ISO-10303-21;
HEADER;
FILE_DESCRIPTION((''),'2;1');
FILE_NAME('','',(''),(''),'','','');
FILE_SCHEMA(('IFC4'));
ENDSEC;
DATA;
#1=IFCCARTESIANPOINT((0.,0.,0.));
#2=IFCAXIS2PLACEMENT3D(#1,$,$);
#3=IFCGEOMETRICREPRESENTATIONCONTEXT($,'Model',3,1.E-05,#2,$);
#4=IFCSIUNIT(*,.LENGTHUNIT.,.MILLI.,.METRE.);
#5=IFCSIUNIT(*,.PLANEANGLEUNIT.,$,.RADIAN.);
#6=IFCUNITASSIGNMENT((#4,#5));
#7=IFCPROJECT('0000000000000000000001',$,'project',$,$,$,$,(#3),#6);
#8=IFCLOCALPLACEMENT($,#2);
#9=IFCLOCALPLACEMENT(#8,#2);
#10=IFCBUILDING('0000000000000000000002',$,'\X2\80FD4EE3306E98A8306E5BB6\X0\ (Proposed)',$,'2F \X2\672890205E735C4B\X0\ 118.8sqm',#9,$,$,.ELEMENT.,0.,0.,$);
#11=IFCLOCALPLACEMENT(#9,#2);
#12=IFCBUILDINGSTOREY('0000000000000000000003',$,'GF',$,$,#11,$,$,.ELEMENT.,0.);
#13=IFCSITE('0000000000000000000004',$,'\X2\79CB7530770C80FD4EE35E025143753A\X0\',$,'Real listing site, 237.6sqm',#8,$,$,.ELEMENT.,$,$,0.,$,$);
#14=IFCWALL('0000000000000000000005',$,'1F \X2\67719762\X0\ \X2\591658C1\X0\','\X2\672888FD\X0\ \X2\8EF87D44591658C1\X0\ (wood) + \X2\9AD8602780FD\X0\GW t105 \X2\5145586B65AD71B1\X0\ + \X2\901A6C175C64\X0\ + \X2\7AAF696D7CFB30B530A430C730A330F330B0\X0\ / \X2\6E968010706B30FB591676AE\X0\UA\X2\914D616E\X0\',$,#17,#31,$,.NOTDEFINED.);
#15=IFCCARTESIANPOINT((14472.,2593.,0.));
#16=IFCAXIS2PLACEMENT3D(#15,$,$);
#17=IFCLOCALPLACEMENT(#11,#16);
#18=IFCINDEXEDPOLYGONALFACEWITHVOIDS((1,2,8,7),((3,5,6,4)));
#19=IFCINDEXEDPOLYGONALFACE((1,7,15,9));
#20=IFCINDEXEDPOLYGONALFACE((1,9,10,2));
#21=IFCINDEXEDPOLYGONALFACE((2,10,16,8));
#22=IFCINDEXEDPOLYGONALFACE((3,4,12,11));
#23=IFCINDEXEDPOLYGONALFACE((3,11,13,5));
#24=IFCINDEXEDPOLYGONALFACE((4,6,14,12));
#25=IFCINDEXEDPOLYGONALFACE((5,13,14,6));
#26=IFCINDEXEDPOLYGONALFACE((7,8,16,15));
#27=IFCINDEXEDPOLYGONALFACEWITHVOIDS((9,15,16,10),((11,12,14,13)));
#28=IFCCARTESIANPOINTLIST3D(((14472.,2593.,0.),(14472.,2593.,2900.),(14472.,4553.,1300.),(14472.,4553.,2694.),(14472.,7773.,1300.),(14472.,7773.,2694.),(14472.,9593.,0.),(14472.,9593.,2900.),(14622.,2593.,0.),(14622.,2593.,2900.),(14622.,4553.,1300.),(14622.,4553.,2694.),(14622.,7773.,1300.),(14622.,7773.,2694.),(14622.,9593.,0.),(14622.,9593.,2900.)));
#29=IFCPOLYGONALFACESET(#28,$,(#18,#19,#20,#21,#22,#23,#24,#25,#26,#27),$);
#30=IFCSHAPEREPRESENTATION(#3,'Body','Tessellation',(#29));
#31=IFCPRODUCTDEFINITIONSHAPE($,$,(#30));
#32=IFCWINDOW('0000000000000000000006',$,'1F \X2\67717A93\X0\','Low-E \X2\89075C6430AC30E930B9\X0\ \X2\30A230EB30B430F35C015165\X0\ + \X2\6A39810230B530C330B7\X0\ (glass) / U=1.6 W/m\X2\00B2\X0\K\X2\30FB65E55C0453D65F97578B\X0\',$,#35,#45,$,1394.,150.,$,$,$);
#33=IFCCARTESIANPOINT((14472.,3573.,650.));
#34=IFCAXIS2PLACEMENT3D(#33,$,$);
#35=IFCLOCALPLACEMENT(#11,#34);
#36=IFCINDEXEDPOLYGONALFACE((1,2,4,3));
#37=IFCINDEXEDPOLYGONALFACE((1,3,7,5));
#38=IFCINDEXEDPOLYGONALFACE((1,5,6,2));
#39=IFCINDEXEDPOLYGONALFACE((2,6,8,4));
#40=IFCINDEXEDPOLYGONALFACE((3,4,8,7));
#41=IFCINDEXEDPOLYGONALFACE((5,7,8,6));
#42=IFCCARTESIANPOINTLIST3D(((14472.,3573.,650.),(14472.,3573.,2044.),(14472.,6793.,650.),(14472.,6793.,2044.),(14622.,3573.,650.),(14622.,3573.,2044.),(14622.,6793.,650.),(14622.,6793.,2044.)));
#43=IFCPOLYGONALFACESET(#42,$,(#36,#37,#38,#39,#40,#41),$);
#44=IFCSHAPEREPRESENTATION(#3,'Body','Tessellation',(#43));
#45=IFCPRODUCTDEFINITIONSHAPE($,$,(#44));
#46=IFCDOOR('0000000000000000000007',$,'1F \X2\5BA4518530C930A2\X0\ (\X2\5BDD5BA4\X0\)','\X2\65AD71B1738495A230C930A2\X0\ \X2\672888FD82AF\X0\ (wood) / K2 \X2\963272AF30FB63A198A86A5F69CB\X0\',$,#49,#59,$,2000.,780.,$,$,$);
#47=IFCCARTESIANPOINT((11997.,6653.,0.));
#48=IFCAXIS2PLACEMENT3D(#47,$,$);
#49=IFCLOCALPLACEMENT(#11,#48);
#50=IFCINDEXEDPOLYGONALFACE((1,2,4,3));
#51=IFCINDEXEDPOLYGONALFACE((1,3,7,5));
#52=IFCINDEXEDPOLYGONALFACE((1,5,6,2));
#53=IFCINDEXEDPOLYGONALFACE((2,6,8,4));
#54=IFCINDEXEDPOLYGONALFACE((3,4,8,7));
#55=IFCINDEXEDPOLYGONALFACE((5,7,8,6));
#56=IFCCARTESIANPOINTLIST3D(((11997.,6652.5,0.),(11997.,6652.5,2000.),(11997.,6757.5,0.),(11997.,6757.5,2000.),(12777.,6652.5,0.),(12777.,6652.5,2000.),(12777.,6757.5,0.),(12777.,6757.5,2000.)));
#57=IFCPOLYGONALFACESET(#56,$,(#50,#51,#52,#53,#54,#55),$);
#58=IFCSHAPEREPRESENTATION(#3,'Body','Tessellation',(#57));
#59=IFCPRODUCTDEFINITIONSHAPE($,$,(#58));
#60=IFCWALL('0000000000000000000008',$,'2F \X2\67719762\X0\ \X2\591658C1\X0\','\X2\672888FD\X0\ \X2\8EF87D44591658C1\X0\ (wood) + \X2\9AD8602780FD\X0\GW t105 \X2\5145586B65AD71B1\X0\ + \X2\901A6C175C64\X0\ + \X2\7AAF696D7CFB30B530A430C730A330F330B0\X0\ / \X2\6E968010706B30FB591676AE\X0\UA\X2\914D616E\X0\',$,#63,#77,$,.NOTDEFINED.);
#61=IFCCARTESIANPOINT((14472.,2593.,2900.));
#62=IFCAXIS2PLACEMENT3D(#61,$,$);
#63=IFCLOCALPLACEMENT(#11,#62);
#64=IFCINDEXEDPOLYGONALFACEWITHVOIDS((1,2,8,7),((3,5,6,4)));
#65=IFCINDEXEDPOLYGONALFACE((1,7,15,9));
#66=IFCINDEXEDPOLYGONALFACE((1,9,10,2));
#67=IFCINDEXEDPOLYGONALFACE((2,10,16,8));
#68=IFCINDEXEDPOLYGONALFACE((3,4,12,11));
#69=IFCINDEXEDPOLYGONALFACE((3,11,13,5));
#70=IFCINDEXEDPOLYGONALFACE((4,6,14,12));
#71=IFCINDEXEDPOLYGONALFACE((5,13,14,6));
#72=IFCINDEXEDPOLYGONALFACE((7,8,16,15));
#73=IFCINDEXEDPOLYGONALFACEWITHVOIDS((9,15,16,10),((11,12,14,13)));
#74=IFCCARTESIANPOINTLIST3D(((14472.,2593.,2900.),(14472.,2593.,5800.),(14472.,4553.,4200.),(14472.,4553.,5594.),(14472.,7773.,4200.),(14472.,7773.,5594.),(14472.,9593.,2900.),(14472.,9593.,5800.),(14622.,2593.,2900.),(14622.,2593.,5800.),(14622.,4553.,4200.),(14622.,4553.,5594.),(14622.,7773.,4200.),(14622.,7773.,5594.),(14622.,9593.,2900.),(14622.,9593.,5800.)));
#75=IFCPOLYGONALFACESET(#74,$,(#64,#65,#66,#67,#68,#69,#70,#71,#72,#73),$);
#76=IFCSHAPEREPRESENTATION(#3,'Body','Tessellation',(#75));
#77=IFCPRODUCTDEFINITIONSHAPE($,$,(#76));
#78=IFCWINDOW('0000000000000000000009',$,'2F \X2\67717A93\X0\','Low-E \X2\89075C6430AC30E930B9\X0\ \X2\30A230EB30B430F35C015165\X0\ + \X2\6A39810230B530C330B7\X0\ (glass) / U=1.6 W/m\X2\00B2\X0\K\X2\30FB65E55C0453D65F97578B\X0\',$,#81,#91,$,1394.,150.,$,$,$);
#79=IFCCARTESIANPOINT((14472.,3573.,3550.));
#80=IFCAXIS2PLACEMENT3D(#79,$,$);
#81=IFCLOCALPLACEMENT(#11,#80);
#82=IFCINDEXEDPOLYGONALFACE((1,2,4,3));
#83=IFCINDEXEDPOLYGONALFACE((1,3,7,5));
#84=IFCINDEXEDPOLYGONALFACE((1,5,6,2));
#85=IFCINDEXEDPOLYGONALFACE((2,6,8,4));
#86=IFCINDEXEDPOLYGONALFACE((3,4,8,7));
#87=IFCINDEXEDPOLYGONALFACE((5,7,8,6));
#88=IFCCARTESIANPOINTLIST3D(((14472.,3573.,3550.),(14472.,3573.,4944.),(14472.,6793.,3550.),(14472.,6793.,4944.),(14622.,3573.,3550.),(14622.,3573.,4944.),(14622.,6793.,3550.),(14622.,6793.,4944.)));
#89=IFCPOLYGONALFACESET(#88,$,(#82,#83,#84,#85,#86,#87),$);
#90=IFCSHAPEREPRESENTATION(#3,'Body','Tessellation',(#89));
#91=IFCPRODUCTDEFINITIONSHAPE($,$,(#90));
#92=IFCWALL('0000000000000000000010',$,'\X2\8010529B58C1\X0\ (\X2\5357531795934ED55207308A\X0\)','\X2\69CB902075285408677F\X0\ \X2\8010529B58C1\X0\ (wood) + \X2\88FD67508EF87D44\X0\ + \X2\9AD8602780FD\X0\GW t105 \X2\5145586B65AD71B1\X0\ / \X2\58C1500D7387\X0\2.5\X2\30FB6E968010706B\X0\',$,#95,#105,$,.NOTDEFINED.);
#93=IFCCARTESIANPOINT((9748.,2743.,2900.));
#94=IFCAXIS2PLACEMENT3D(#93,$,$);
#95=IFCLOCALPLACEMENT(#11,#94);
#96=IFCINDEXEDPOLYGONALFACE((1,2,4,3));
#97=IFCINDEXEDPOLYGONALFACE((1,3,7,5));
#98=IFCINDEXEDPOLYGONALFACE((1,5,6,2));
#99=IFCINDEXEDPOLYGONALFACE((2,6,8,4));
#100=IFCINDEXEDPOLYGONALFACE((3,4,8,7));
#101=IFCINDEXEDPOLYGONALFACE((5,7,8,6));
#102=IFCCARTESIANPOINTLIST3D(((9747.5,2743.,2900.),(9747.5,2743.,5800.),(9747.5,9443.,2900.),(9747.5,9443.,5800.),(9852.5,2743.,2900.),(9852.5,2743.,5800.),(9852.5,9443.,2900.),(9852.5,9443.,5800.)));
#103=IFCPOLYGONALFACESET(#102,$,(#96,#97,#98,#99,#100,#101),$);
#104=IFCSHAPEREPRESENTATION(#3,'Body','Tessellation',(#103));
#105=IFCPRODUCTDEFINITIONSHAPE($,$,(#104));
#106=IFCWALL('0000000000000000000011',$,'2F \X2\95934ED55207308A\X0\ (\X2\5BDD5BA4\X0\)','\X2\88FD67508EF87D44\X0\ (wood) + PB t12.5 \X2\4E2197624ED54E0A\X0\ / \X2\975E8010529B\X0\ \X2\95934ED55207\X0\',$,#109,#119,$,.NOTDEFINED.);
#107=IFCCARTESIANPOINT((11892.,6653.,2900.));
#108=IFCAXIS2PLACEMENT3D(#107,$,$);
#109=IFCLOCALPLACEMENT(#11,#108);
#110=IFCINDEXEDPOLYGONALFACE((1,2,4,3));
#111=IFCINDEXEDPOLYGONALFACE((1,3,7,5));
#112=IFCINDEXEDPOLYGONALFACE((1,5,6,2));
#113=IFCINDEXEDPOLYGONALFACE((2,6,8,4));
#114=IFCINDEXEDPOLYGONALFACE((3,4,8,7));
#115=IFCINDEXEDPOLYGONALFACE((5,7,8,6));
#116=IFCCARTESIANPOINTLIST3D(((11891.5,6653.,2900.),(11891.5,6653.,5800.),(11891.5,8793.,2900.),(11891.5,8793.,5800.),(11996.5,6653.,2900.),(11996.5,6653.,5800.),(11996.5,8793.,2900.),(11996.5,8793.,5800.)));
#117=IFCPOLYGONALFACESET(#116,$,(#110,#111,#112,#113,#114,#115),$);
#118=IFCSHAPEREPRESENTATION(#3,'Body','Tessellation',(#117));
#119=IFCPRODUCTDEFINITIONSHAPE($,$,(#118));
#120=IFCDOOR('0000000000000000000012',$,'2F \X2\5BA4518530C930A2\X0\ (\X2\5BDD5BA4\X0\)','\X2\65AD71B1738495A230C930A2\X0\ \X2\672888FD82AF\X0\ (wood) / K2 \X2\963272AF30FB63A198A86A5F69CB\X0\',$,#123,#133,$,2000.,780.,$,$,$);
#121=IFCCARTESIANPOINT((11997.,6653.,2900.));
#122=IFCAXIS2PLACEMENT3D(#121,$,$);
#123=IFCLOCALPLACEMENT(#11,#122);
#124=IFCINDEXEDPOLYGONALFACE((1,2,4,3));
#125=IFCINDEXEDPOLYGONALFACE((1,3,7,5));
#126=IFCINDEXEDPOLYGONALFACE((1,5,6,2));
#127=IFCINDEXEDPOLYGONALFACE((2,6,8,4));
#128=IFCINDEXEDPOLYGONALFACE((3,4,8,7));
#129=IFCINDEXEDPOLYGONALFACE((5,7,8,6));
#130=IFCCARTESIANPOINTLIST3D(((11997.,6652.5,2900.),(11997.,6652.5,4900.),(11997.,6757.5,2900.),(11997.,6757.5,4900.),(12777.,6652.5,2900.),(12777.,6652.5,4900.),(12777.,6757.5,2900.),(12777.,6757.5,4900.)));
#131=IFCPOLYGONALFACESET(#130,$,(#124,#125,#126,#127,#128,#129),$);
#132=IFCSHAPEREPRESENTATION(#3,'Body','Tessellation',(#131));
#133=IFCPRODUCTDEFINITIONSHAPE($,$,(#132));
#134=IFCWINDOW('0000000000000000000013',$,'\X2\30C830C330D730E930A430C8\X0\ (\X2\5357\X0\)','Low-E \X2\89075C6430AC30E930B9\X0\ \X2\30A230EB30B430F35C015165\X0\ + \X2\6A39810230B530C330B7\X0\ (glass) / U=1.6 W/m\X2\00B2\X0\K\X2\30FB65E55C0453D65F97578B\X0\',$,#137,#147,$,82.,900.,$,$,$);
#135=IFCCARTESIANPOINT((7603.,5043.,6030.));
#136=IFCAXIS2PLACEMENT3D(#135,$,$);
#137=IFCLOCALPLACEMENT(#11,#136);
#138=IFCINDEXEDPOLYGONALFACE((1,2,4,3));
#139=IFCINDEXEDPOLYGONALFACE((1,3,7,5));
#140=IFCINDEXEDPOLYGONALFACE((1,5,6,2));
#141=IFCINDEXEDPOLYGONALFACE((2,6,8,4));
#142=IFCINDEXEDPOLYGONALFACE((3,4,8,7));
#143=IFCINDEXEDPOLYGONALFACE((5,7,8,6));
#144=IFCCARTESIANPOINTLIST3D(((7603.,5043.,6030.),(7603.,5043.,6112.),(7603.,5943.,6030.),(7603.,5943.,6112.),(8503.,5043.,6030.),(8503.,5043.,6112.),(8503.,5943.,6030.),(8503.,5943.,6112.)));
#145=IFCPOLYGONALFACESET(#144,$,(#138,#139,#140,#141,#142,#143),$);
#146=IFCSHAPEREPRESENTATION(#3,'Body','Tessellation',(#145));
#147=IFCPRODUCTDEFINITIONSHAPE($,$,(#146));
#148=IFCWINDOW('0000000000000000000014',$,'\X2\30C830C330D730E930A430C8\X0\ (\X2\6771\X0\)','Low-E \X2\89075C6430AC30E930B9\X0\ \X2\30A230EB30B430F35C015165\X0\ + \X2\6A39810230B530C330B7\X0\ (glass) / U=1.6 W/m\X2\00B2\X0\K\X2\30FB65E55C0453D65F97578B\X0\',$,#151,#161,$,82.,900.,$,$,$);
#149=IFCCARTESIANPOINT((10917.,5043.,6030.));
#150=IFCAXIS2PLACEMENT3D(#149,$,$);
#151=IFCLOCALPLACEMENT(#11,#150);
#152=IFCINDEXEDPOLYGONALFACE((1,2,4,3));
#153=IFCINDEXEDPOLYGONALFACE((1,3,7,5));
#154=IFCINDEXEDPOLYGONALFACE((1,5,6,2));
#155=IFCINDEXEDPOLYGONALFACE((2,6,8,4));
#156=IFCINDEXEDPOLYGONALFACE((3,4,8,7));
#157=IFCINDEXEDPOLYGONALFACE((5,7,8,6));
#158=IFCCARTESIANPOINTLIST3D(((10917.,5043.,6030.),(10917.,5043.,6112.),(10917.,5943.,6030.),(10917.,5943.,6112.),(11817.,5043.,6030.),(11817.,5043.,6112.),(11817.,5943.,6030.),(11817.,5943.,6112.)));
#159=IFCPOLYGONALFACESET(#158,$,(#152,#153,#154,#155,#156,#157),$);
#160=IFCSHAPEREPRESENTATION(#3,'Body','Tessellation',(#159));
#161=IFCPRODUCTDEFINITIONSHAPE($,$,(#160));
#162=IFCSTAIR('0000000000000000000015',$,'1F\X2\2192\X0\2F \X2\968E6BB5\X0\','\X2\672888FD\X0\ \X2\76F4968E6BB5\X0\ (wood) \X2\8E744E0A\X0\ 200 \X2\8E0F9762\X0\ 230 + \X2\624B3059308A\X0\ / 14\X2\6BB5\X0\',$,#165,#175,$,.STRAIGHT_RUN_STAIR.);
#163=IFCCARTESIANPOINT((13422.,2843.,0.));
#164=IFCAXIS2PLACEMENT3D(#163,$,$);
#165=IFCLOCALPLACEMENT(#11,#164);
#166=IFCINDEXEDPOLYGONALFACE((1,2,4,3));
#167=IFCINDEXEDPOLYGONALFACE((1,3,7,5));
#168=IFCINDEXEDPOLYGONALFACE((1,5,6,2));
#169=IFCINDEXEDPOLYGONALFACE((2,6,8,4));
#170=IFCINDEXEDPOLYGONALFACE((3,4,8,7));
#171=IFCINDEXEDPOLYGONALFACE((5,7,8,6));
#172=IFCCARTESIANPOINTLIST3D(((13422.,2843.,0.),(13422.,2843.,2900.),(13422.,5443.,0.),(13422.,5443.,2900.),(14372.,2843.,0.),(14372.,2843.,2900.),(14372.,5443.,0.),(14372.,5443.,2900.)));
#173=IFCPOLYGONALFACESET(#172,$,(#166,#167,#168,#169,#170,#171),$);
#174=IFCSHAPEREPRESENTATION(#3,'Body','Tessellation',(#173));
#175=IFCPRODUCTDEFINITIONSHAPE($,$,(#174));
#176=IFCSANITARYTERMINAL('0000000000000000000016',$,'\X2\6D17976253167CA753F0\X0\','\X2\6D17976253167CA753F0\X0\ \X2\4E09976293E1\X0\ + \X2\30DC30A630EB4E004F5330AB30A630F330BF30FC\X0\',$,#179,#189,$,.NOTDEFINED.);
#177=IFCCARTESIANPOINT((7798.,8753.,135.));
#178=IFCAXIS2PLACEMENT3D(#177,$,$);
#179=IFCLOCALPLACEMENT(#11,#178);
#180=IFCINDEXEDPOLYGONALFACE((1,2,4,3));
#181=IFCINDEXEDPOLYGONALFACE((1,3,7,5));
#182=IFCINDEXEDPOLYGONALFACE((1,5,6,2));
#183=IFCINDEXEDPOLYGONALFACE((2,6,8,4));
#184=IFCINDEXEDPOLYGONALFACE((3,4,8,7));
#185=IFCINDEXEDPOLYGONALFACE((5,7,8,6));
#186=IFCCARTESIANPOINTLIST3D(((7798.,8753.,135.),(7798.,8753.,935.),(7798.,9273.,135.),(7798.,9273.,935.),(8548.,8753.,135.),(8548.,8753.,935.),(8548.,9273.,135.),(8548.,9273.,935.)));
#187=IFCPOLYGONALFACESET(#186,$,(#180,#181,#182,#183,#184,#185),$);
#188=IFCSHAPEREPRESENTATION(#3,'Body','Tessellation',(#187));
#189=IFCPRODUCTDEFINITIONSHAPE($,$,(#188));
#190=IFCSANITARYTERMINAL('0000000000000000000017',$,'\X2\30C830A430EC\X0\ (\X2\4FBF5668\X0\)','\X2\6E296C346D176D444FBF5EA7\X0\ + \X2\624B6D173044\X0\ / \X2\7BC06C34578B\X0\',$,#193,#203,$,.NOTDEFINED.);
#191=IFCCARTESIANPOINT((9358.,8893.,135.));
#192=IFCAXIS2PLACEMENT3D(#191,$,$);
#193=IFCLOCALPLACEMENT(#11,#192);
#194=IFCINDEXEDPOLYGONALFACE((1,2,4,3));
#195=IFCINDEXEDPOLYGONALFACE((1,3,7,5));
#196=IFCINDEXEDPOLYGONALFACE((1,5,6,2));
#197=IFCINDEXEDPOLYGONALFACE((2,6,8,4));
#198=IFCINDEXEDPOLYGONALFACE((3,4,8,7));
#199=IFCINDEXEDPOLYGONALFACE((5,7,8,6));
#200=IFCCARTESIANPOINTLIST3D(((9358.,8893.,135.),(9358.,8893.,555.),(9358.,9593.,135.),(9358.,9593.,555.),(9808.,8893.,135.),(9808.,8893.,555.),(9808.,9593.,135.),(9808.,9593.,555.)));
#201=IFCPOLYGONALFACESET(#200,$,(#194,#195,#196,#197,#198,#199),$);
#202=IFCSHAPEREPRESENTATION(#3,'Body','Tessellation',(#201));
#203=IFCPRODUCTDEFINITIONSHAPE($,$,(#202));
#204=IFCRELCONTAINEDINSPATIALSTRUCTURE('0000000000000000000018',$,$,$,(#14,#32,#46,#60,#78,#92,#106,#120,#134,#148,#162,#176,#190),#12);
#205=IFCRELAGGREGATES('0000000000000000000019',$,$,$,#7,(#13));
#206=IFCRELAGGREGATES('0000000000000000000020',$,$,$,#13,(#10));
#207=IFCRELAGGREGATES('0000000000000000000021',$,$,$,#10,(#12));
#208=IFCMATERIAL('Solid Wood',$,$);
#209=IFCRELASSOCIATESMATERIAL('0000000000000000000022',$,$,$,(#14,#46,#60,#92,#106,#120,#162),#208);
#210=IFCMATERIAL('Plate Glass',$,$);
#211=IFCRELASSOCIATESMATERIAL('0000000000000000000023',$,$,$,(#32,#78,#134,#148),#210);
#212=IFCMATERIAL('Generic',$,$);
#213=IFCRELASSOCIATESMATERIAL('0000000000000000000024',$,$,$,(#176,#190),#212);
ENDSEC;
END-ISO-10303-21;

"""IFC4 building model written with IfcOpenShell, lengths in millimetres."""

from ifc_helpers import new_model, si_unit, frame, frame_2d, origin, place, context, project, spatial, rectangle, extrude, material, element, fill, save


model = new_model("IFC4")

# Units and contexts
model_context = context("Model", 3, precision=1e-05, world=origin())
ifc_project = project(units=[si_unit("LENGTHUNIT", "METRE", prefix="MILLI"), si_unit("PLANEANGLEUNIT", "RADIAN")], contexts=[model_context])

# Site, building, storey
site_placement = place(None, origin())
site = spatial("IfcSite", under=ifc_project, at=site_placement, Name="秋田県能代市元町", ObjectType="Real listing site, 237.6sqm", CompositionType="ELEMENT", RefElevation=0.0)
building_placement = place(site_placement, origin())
building = spatial("IfcBuilding", under=site, at=building_placement, Name="能代の風の家 (Proposed)", ObjectType="2F 木造平屋 118.8sqm", CompositionType="ELEMENT", ElevationOfRefHeight=0.0, ElevationOfTerrain=0.0)
storey_placement = place(building_placement, origin())
storey = spatial("IfcBuildingStorey", under=building, at=storey_placement, Name="GF", CompositionType="ELEMENT", Elevation=0.0)

# Wall, opening, window
ifc_material_1 = material(Name="Solid Wood")
wall_1_placement = place(storey_placement, frame((14472.0, 2593.0, 0.0)))
wall_1 = element("IfcWall", 1, at=wall_1_placement, inside=storey, material=ifc_material_1, Name="1F 東面 外壁", Description="木製 軸組外壁 (wood) + 高性能GW t105 充填断熱 + 通気層 + 窯業系サイディング / 準耐火・外皮UA配慮", PredefinedType="NOTDEFINED", context=model_context, shape_type="SweptSolid", body=[
    extrude(rectangle(XDim=150.0, YDim=7000.0, at=frame_2d((75.0, 3500.0))), frame((14472.0, 2593.0, 0.0)), (0.0, 0.0, 1.0), 2900.0),
])
opening_1_placement = place(storey_placement, frame((14472.0, 3573.0, 650.0)))
opening_1 = element("IfcOpeningElement", 2, at=opening_1_placement, cuts=wall_1, PredefinedType="NOTDEFINED", context=model_context, shape_type="SweptSolid", body=[
    extrude(rectangle(XDim=150.0, YDim=3220.0, at=frame_2d((75.0, 1610.0))), frame((14472.0, 3573.0, 650.0)), (0.0, 0.0, 1.0), 1394.0),
])
ifc_material_2 = material(Name="Plate Glass")
window_1_placement = place(storey_placement, frame((14472.0, 3573.0, 650.0)))
window_1 = element("IfcWindow", 3, at=window_1_placement, inside=storey, material=ifc_material_2, Name="1F 東窓", Description="Low-E 複層ガラス アルゴン封入 + 樹脂サッシ (glass) / U=1.6 W/m²K・日射取得型", OverallHeight=1394.0, OverallWidth=150.0, context=model_context, shape_type="SweptSolid", body=[
    extrude(rectangle(XDim=150.0, YDim=3220.0, at=frame_2d((75.0, 1610.0))), frame((14472.0, 3573.0, 650.0)), (0.0, 0.0, 1.0), 1394.0),
])
fill(opening_1, window_1)

# Door
door_1_placement = place(storey_placement, frame((11997.0, 6653.0, 0.0)))
element("IfcDoor", 4, at=door_1_placement, inside=storey, material=ifc_material_1, Name="1F 室内ドア (寝室)", Description="断熱玄関ドア 木製芯 (wood) / K2 防犯・採風機構", OverallHeight=2000.0, OverallWidth=780.0, context=model_context, shape_type="SweptSolid", body=[
    extrude(rectangle(XDim=780.0, YDim=105.0, at=frame_2d((390.0, 52.0))), frame((11997.0, 6653.0, 0.0)), (0.0, 0.0, 1.0), 2000.0),
])

# Wall, opening, window
wall_2_placement = place(storey_placement, frame((14472.0, 2593.0, 2900.0)))
wall_2 = element("IfcWall", 5, at=wall_2_placement, inside=storey, material=ifc_material_1, Name="2F 東面 外壁", Description="木製 軸組外壁 (wood) + 高性能GW t105 充填断熱 + 通気層 + 窯業系サイディング / 準耐火・外皮UA配慮", PredefinedType="NOTDEFINED", context=model_context, shape_type="SweptSolid", body=[
    extrude(rectangle(XDim=150.0, YDim=7000.0, at=frame_2d((75.0, 3500.0))), frame((14472.0, 2593.0, 2900.0)), (0.0, 0.0, 1.0), 2900.0),
])
opening_2_placement = place(storey_placement, frame((14472.0, 3573.0, 3550.0)))
opening_2 = element("IfcOpeningElement", 6, at=opening_2_placement, cuts=wall_2, PredefinedType="NOTDEFINED", context=model_context, shape_type="SweptSolid", body=[
    extrude(rectangle(XDim=150.0, YDim=3220.0, at=frame_2d((75.0, 1610.0))), frame((14472.0, 3573.0, 3550.0)), (0.0, 0.0, 1.0), 1394.0),
])
window_2_placement = place(storey_placement, frame((14472.0, 3573.0, 3550.0)))
window_2 = element("IfcWindow", 7, at=window_2_placement, inside=storey, material=ifc_material_2, Name="2F 東窓", Description="Low-E 複層ガラス アルゴン封入 + 樹脂サッシ (glass) / U=1.6 W/m²K・日射取得型", OverallHeight=1394.0, OverallWidth=150.0, context=model_context, shape_type="SweptSolid", body=[
    extrude(rectangle(XDim=150.0, YDim=3220.0, at=frame_2d((75.0, 1610.0))), frame((14472.0, 3573.0, 3550.0)), (0.0, 0.0, 1.0), 1394.0),
])
fill(opening_2, window_2)

# Walls
wall_3_placement = place(storey_placement, frame((9748.0, 2743.0, 2900.0)))
element("IfcWall", 8, at=wall_3_placement, inside=storey, material=ifc_material_1, Name="耐力壁 (南北間仕切り)", Description="構造用合板 耐力壁 (wood) + 製材軸組 + 高性能GW t105 充填断熱 / 壁倍率2.5・準耐火", PredefinedType="NOTDEFINED", context=model_context, shape_type="SweptSolid", body=[
    extrude(rectangle(XDim=105.0, YDim=6700.0, at=frame_2d((52.0, 3350.0))), frame((9748.0, 2743.0, 2900.0)), (0.0, 0.0, 1.0), 2900.0),
])
wall_4_placement = place(storey_placement, frame((11892.0, 6653.0, 2900.0)))
element("IfcWall", 9, at=wall_4_placement, inside=storey, material=ifc_material_1, Name="2F 間仕切り (寝室)", Description="製材軸組 (wood) + PB t12.5 両面仕上 / 非耐力 間仕切", PredefinedType="NOTDEFINED", context=model_context, shape_type="SweptSolid", body=[
    extrude(rectangle(XDim=105.0, YDim=2140.0, at=frame_2d((52.0, 1070.0))), frame((11892.0, 6653.0, 2900.0)), (0.0, 0.0, 1.0), 2900.0),
])

# Door
door_2_placement = place(storey_placement, frame((11997.0, 6653.0, 2900.0)))
element("IfcDoor", 10, at=door_2_placement, inside=storey, material=ifc_material_1, Name="2F 室内ドア (寝室)", Description="断熱玄関ドア 木製芯 (wood) / K2 防犯・採風機構", OverallHeight=2000.0, OverallWidth=780.0, context=model_context, shape_type="SweptSolid", body=[
    extrude(rectangle(XDim=780.0, YDim=105.0, at=frame_2d((390.0, 52.0))), frame((11997.0, 6653.0, 2900.0)), (0.0, 0.0, 1.0), 2000.0),
])

# Windows
window_3_placement = place(storey_placement, frame((7603.0, 5043.0, 6030.0)))
element("IfcWindow", 11, at=window_3_placement, inside=storey, material=ifc_material_2, Name="トップライト (南)", Description="Low-E 複層ガラス アルゴン封入 + 樹脂サッシ (glass) / U=1.6 W/m²K・日射取得型", OverallHeight=82.0, OverallWidth=900.0, context=model_context, shape_type="SweptSolid", body=[
    extrude(rectangle(XDim=900.0, YDim=900.0, at=frame_2d((450.0, 450.0))), frame((7603.0, 5043.0, 6030.0)), (0.0, 0.0, 1.0), 82.0),
])
window_4_placement = place(storey_placement, frame((10917.0, 5043.0, 6030.0)))
element("IfcWindow", 12, at=window_4_placement, inside=storey, material=ifc_material_2, Name="トップライト (東)", Description="Low-E 複層ガラス アルゴン封入 + 樹脂サッシ (glass) / U=1.6 W/m²K・日射取得型", OverallHeight=82.0, OverallWidth=900.0, context=model_context, shape_type="SweptSolid", body=[
    extrude(rectangle(XDim=900.0, YDim=900.0, at=frame_2d((450.0, 450.0))), frame((10917.0, 5043.0, 6030.0)), (0.0, 0.0, 1.0), 82.0),
])

# Stair
stair_placement = place(storey_placement, frame((13422.0, 2843.0, 0.0)))
element("IfcStair", 13, at=stair_placement, inside=storey, material=ifc_material_1, Name="1F→2F 階段", Description="木製 直階段 (wood) 蹴上 200 踏面 230 + 手すり / 14段", PredefinedType="STRAIGHT_RUN_STAIR", context=model_context, shape_type="SweptSolid", body=[
    extrude(rectangle(XDim=950.0, YDim=2600.0, at=frame_2d((475.0, 1300.0))), frame((13422.0, 2843.0, 0.0)), (0.0, 0.0, 1.0), 2900.0),
])

# Sanitary terminals
ifc_material_3 = material(Name="Generic")
sanitary_terminal_1_placement = place(storey_placement, frame((7798.0, 8753.0, 135.0)))
element("IfcSanitaryTerminal", 14, at=sanitary_terminal_1_placement, inside=storey, material=ifc_material_3, Name="洗面化粧台", Description="洗面化粧台 三面鏡 + ボウル一体カウンター", PredefinedType="NOTDEFINED", context=model_context, shape_type="SweptSolid", body=[
    extrude(rectangle(XDim=750.0, YDim=520.0, at=frame_2d((375.0, 260.0))), frame((7798.0, 8753.0, 135.0)), (0.0, 0.0, 1.0), 800.0),
])
sanitary_terminal_2_placement = place(storey_placement, frame((9358.0, 8893.0, 135.0)))
element("IfcSanitaryTerminal", 15, at=sanitary_terminal_2_placement, inside=storey, material=ifc_material_3, Name="トイレ (便器)", Description="温水洗浄便座 + 手洗い / 節水型", PredefinedType="NOTDEFINED", context=model_context, shape_type="SweptSolid", body=[
    extrude(rectangle(XDim=450.0, YDim=700.0, at=frame_2d((225.0, 350.0))), frame((9358.0, 8893.0, 135.0)), (0.0, 0.0, 1.0), 420.0),
])

save(model, "model.ifc")
